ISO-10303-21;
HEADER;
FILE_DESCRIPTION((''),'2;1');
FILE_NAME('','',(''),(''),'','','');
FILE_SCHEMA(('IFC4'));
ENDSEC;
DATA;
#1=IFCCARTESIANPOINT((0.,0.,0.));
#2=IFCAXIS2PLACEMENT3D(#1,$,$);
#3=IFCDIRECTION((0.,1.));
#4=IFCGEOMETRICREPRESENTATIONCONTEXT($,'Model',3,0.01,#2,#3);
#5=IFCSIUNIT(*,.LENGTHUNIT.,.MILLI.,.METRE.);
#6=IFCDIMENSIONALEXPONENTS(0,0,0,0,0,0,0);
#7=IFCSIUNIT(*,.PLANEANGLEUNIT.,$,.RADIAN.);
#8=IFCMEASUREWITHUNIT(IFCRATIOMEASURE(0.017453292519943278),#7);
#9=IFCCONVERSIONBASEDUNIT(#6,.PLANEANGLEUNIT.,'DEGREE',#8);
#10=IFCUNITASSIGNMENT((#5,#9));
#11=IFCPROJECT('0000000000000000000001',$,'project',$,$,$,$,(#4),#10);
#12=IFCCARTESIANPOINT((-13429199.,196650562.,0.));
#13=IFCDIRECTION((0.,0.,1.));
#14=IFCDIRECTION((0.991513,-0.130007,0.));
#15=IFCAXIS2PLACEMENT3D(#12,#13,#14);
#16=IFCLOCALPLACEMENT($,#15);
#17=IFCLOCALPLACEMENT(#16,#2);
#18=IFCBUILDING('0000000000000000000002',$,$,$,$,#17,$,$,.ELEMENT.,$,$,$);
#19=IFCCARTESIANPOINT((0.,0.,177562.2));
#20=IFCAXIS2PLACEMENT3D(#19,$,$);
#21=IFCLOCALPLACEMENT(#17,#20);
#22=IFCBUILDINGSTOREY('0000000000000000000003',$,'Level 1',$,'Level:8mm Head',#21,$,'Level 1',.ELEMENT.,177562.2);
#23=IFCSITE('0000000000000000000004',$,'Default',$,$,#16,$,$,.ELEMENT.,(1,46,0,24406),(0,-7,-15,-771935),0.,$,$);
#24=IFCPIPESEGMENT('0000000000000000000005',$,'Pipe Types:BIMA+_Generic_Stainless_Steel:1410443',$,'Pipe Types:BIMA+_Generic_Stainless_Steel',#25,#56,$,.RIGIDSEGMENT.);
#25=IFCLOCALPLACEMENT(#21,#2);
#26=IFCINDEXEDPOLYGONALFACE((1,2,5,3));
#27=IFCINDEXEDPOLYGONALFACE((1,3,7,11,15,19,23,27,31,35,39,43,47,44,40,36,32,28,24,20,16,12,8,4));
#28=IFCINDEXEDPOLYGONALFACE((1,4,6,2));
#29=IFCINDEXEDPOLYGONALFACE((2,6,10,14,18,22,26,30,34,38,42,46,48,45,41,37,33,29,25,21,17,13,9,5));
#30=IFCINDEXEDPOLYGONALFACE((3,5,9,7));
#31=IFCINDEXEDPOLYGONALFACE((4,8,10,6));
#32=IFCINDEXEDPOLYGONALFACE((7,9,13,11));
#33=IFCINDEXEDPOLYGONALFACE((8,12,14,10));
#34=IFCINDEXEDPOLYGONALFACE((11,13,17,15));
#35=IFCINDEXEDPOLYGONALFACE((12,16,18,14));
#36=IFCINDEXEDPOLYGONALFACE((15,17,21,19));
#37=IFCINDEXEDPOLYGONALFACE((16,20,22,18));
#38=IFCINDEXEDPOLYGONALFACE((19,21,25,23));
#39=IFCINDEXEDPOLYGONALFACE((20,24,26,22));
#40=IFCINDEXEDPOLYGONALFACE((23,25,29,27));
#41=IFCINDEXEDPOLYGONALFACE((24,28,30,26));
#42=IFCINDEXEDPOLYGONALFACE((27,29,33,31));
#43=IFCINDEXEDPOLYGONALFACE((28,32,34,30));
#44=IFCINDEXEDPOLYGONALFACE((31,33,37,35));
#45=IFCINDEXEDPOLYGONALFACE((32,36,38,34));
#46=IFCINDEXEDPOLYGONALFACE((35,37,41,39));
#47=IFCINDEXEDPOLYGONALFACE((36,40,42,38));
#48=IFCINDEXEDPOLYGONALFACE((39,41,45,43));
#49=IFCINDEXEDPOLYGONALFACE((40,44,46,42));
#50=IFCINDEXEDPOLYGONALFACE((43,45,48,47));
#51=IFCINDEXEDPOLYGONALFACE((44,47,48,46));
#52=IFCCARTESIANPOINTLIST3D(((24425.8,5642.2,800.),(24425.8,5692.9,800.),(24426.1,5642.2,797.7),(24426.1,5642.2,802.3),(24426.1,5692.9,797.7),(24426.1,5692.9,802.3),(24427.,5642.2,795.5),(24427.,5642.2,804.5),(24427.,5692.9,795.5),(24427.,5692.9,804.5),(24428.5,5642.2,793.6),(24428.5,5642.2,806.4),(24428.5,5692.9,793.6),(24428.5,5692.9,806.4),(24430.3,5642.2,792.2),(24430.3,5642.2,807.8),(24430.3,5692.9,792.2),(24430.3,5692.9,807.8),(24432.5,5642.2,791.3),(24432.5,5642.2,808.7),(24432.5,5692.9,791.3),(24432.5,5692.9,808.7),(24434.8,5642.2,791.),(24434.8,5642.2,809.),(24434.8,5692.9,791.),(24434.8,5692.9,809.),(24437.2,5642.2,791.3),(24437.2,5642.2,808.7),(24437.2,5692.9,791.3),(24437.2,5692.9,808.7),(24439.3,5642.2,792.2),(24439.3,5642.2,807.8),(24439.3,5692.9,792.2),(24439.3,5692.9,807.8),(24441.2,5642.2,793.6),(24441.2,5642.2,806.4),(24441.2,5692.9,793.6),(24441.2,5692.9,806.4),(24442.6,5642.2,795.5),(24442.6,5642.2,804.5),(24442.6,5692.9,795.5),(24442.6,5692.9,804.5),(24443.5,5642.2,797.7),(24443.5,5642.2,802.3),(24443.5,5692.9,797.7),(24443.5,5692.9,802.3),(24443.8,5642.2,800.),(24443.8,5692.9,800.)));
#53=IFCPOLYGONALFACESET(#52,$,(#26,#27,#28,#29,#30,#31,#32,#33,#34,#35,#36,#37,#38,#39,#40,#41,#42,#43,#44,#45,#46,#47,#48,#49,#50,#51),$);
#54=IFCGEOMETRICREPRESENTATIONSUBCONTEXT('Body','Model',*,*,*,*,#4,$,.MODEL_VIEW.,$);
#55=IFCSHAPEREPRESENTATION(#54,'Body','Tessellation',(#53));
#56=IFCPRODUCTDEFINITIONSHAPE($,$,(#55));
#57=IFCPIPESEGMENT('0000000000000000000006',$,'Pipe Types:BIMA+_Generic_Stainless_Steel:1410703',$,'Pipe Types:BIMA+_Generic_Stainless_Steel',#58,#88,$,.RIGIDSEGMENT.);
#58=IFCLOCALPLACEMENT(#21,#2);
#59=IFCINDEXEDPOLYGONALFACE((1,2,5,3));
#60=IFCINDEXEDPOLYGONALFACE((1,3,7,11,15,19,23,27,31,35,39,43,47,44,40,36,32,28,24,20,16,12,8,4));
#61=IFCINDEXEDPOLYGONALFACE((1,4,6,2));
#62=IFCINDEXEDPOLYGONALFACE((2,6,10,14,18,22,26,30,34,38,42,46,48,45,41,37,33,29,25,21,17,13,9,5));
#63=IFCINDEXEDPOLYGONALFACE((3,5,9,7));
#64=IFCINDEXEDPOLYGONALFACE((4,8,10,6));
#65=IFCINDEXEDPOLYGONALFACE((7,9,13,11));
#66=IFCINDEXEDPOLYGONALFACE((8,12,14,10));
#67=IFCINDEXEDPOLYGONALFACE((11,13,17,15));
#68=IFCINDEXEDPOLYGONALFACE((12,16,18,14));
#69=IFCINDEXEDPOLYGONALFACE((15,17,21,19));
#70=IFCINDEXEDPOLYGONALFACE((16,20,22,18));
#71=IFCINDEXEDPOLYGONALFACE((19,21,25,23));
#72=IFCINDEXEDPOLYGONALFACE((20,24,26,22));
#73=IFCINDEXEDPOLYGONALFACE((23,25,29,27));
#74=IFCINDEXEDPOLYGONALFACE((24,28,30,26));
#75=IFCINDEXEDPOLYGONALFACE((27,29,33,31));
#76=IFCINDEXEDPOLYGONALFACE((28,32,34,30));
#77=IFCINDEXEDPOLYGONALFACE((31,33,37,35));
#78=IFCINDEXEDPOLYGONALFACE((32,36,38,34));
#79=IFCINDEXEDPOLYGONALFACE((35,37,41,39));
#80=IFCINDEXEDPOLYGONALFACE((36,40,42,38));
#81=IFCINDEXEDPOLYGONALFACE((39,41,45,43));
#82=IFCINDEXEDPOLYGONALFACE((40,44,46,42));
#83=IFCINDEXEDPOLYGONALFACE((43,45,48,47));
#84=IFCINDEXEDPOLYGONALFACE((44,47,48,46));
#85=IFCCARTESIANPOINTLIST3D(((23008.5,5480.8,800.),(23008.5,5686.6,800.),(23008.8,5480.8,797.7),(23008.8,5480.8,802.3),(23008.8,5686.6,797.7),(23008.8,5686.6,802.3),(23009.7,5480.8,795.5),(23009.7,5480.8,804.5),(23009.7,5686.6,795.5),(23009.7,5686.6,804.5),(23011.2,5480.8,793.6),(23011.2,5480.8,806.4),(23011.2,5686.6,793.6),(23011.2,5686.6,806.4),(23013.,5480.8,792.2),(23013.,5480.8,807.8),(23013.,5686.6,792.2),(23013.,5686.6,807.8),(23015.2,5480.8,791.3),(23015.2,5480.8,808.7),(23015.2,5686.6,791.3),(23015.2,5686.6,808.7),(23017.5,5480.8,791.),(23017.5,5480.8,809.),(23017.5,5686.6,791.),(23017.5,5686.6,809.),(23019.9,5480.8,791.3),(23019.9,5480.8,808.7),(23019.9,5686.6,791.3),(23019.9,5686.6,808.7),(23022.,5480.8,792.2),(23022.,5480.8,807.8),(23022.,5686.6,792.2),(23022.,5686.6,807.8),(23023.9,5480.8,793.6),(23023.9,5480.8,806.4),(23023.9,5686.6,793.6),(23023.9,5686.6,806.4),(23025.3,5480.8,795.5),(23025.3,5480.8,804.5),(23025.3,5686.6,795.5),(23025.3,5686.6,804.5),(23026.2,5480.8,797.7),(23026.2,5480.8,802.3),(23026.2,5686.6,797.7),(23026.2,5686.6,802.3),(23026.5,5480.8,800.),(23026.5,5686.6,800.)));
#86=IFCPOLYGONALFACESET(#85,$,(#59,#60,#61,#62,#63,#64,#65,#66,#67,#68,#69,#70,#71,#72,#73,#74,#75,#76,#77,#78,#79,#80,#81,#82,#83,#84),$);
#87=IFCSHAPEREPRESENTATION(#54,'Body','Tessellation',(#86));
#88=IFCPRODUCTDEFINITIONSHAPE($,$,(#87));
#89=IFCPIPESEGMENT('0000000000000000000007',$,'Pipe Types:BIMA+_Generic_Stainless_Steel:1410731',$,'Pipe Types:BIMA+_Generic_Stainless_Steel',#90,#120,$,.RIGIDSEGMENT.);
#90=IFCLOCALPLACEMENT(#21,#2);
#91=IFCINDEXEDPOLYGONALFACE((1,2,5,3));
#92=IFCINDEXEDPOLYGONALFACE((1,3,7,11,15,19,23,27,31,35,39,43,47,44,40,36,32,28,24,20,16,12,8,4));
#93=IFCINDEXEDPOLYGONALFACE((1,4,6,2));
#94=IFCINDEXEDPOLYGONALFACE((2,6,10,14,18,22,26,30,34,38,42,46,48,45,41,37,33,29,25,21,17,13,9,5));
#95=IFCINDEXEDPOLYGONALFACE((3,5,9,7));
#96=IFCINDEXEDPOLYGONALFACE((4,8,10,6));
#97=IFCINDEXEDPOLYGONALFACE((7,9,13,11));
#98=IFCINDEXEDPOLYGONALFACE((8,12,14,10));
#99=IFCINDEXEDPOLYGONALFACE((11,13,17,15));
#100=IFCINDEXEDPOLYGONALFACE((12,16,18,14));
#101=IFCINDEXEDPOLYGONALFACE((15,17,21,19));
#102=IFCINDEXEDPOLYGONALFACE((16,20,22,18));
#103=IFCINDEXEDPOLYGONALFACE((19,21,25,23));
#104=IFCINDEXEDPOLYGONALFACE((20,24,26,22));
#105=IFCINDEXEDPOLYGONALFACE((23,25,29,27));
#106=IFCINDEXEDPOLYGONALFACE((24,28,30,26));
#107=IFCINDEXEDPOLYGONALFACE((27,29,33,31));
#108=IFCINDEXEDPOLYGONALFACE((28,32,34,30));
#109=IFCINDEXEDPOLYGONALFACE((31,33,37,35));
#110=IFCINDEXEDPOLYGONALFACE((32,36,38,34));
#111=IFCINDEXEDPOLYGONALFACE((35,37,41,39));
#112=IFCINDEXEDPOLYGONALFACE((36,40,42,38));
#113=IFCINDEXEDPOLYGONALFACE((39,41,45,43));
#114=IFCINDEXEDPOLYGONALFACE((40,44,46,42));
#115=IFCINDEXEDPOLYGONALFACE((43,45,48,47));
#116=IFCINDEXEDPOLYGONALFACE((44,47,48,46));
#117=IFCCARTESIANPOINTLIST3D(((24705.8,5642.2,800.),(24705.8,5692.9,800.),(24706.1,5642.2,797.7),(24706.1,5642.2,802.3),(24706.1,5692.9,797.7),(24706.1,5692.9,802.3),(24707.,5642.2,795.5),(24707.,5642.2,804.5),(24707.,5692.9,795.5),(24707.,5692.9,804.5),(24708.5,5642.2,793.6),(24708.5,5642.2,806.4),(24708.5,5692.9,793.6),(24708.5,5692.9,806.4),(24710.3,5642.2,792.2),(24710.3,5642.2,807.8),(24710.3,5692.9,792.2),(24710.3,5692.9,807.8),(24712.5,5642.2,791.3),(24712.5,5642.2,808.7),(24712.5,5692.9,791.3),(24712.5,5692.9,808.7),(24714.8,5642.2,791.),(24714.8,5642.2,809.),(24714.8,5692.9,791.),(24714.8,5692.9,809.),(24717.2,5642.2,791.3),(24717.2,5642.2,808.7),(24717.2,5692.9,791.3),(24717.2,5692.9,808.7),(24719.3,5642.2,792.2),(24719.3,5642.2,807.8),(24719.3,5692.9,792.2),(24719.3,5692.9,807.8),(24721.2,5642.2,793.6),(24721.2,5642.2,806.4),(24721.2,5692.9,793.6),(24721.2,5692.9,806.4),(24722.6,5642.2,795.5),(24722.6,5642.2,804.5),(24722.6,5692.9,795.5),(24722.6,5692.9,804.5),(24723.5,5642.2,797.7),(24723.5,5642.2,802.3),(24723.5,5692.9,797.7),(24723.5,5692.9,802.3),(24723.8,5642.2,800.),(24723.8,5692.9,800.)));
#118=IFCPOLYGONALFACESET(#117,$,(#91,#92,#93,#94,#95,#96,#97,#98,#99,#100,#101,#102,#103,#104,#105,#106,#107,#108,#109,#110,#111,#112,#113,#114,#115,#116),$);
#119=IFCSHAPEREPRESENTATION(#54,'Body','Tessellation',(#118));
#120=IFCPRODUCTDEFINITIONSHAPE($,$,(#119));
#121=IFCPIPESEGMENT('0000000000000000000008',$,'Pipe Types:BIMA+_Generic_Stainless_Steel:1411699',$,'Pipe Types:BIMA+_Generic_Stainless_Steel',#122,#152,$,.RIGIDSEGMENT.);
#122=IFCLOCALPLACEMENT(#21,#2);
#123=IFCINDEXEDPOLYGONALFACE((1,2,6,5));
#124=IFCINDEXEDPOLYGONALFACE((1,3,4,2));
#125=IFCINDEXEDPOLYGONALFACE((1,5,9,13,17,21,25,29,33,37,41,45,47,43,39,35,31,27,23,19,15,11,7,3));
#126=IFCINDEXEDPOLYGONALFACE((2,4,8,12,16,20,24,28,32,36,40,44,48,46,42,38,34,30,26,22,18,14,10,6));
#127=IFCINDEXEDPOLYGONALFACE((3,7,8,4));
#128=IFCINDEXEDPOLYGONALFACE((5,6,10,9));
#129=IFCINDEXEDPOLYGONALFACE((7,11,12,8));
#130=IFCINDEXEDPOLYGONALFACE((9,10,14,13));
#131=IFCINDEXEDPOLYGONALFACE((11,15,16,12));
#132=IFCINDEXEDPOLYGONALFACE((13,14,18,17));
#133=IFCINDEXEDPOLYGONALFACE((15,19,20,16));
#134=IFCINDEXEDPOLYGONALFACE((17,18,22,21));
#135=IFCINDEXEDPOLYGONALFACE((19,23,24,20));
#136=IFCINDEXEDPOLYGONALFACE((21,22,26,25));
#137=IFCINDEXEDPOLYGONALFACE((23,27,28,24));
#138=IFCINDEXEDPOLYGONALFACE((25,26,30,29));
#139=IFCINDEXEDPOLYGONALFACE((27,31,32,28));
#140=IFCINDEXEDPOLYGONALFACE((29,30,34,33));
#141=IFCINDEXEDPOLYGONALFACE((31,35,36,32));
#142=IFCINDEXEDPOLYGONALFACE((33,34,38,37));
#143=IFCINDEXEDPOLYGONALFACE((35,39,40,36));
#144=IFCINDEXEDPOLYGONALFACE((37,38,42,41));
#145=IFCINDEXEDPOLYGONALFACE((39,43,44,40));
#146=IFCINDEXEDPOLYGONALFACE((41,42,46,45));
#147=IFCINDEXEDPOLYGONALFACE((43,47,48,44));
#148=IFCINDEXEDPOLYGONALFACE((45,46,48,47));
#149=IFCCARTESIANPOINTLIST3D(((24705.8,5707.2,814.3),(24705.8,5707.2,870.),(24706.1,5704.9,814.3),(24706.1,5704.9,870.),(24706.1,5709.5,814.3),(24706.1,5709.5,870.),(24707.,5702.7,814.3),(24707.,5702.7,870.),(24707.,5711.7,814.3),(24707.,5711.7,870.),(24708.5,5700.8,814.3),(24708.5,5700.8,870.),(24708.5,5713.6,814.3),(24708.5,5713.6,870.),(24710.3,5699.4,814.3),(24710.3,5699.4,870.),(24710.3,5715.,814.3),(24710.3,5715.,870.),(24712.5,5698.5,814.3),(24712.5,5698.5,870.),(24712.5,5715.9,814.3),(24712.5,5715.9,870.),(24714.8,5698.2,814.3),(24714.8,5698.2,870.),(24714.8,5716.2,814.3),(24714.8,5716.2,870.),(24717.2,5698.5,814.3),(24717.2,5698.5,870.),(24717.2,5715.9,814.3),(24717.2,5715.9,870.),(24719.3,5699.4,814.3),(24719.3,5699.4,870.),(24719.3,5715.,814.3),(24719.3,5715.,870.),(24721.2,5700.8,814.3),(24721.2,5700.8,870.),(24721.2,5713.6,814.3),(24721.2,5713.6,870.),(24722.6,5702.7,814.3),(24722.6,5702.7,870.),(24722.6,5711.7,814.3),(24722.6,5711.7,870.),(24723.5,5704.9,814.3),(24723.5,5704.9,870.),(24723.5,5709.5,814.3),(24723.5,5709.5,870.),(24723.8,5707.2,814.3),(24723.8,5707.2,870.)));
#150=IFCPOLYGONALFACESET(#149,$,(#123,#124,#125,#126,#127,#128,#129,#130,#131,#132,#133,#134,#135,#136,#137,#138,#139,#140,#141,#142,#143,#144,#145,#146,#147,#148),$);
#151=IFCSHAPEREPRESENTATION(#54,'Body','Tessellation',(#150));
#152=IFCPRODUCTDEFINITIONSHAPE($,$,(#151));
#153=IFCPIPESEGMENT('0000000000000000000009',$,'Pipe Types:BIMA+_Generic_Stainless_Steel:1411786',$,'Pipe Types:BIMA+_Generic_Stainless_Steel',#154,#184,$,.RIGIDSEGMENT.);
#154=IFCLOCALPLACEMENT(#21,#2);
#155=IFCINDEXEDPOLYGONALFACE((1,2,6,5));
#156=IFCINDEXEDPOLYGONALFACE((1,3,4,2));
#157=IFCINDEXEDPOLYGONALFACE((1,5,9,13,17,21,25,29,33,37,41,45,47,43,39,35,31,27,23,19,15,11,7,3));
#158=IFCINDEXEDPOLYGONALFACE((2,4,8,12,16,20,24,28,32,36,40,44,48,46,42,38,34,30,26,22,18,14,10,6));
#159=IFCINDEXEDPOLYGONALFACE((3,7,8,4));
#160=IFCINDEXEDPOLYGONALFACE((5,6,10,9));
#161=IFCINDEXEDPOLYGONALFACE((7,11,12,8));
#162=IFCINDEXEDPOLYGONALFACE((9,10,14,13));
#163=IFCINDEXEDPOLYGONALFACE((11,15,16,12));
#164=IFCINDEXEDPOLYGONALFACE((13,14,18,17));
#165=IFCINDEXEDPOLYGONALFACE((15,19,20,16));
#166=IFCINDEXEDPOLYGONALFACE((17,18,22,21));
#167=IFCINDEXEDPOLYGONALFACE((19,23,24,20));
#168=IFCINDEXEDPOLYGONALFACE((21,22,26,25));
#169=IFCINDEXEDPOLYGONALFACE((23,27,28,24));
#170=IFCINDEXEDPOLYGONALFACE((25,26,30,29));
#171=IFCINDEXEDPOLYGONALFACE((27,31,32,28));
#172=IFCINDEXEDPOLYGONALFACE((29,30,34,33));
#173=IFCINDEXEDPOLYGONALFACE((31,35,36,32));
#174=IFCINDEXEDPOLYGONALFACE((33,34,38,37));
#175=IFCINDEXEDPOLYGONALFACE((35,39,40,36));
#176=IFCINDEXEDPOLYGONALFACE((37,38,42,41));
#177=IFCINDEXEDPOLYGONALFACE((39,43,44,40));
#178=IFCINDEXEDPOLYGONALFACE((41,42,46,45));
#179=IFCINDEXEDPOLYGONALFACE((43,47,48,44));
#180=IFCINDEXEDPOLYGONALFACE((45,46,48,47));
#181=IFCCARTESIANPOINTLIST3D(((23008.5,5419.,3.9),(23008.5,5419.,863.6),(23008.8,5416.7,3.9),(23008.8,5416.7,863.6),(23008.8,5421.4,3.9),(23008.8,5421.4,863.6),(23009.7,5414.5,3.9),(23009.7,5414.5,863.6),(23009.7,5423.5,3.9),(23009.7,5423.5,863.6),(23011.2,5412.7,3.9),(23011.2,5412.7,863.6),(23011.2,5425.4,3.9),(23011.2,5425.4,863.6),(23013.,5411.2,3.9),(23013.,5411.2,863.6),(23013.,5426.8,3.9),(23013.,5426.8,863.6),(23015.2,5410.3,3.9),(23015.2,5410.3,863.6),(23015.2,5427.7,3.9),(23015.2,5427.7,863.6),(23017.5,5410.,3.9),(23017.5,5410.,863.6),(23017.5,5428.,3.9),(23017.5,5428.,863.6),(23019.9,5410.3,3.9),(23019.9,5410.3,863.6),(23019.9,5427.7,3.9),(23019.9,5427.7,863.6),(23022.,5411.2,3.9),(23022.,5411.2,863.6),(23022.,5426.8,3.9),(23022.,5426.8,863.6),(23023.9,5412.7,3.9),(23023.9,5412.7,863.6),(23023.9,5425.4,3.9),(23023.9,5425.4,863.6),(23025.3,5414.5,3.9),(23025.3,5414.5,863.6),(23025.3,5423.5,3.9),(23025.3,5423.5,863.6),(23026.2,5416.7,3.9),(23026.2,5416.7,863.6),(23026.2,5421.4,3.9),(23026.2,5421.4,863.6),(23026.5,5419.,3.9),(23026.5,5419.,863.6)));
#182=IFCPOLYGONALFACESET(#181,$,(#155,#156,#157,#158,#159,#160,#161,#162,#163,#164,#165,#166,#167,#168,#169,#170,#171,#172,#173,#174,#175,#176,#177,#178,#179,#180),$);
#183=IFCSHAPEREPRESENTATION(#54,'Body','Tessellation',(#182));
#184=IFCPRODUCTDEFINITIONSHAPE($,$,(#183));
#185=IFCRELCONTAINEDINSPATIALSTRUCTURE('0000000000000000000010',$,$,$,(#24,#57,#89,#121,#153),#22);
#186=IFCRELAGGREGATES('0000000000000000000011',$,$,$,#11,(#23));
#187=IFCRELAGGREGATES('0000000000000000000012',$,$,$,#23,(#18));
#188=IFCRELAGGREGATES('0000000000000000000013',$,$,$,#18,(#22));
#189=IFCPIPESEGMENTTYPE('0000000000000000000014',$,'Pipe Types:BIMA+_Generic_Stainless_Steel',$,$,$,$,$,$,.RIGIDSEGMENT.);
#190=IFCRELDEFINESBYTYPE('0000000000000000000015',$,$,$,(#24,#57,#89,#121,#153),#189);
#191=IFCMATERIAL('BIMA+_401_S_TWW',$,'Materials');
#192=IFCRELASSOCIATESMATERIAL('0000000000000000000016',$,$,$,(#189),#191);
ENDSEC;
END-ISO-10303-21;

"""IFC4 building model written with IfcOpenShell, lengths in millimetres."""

from ifc_helpers import new_model, entity, si_unit, converted_unit, direction, frame, origin, place, context, subcontext, project, spatial, arc, indexed_curve, outline, extrude, material, type_object, element, save


model = new_model("IFC4")

# Units and contexts
model_context = context("Model", 3, precision=0.01, world=origin(), true_north=direction((0.0, 1.0)))
body_context = subcontext(model_context, "Body", "Model", "MODEL_VIEW")
ifc_project = project(units=[si_unit("LENGTHUNIT", "METRE", prefix="MILLI"), converted_unit("PLANEANGLEUNIT", "DEGREE", entity("IfcRatioMeasure", 0.017453292519943278), si_unit("PLANEANGLEUNIT", "RADIAN"), dimensions=[0, 0, 0, 0, 0, 0, 0])], contexts=[model_context])

# Site, building, storey
site_placement = place(None, frame((-13429199.0, 196650562.0, 0.0), z_axis=(0.0, 0.0, 1.0), x_axis=(0.991513, -0.130007, 0.0)))
site = spatial("IfcSite", under=ifc_project, at=site_placement, Name="Default", CompositionType="ELEMENT", RefLatitude=(1, 46, 0, 24406), RefLongitude=(0, -7, -15, -771935), RefElevation=0.0)
building_placement = place(site_placement, origin())
building = spatial("IfcBuilding", under=site, at=building_placement, CompositionType="ELEMENT")
storey_placement = place(building_placement, frame((0.0, 0.0, 177562.2)))
storey = spatial("IfcBuildingStorey", under=building, at=storey_placement, Name="Level 1", ObjectType="Level:8mm Head", LongName="Level 1", CompositionType="ELEMENT", Elevation=177562.2)

# Pipe segments
ifc_material_1 = material(Name="BIMA+_401_S_TWW", Category="Materials")
pipe_segment_type_1 = type_object("IfcPipeSegmentType", Name="Pipe Types:BIMA+_Generic_Stainless_Steel", PredefinedType="RIGIDSEGMENT", material=ifc_material_1)
pipe_segment_1_placement = place(storey_placement, frame((24424.2, 5642.2, 789.4)))
element("IfcPipeSegment", 1, at=pipe_segment_1_placement, inside=storey, type_object=pipe_segment_type_1, Name="Pipe Types:BIMA+_Generic_Stainless_Steel:1410443", ObjectType="Pipe Types:BIMA+_Generic_Stainless_Steel", PredefinedType="RIGIDSEGMENT", context=body_context, shape_type="SweptSolid", body=[
    extrude(outline(indexed_curve([(9.0, 0.0), (6.4, 6.4), (0.0, 9.0), (-6.4, 6.4), (-9.0, 0.0), (-6.4, -6.4), (0.0, -9.0), (6.4, -6.4)], segments=[arc(1, 2, 3), arc(3, 4, 5), arc(5, 6, 7), arc(7, 8, 1)], self_intersect=False)), frame((10.6, 0.0, 10.6), z_axis=(0.0, 1.0, 0.0), x_axis=(-1.0, 0.0, 0.0)), (0.0, 0.0, 1.0), 50.7),
])
pipe_segment_2_placement = place(storey_placement, frame((23006.9, 5480.8, 789.4)))
element("IfcPipeSegment", 2, at=pipe_segment_2_placement, inside=storey, type_object=pipe_segment_type_1, Name="Pipe Types:BIMA+_Generic_Stainless_Steel:1410703", ObjectType="Pipe Types:BIMA+_Generic_Stainless_Steel", PredefinedType="RIGIDSEGMENT", context=body_context, shape_type="SweptSolid", body=[
    extrude(outline(indexed_curve([(9.0, 0.0), (6.4, 6.4), (0.0, 9.0), (-6.4, 6.4), (-9.0, 0.0), (-6.4, -6.4), (0.0, -9.0), (6.4, -6.4)], segments=[arc(1, 2, 3), arc(3, 4, 5), arc(5, 6, 7), arc(7, 8, 1)], self_intersect=False)), frame((10.6, 0.0, 10.6), z_axis=(0.0, 1.0, 0.0), x_axis=(-1.0, 0.0, 0.0)), (0.0, 0.0, 1.0), 205.8),
])
pipe_segment_3_placement = place(storey_placement, frame((24704.2, 5642.2, 789.4)))
element("IfcPipeSegment", 3, at=pipe_segment_3_placement, inside=storey, type_object=pipe_segment_type_1, Name="Pipe Types:BIMA+_Generic_Stainless_Steel:1410731", ObjectType="Pipe Types:BIMA+_Generic_Stainless_Steel", PredefinedType="RIGIDSEGMENT", context=body_context, shape_type="SweptSolid", body=[
    extrude(outline(indexed_curve([(9.0, 0.0), (6.4, 6.4), (0.0, 9.0), (-6.4, 6.4), (-9.0, 0.0), (-6.4, -6.4), (0.0, -9.0), (6.4, -6.4)], segments=[arc(1, 2, 3), arc(3, 4, 5), arc(5, 6, 7), arc(7, 8, 1)], self_intersect=False)), frame((10.6, 0.0, 10.6), z_axis=(0.0, 1.0, 0.0), x_axis=(-1.0, 0.0, 0.0)), (0.0, 0.0, 1.0), 50.7),
])
pipe_segment_4_placement = place(storey_placement, frame((24704.2, 5696.6, 870.0)))
element("IfcPipeSegment", 4, at=pipe_segment_4_placement, inside=storey, type_object=pipe_segment_type_1, Name="Pipe Types:BIMA+_Generic_Stainless_Steel:1411699", ObjectType="Pipe Types:BIMA+_Generic_Stainless_Steel", PredefinedType="RIGIDSEGMENT", context=body_context, shape_type="SweptSolid", body=[
    extrude(outline(indexed_curve([(9.0, 0.0), (6.4, 6.4), (0.0, 9.0), (-6.4, 6.4), (-9.0, 0.0), (-6.4, -6.4), (0.0, -9.0), (6.4, -6.4)], segments=[arc(1, 2, 3), arc(3, 4, 5), arc(5, 6, 7), arc(7, 8, 1)], self_intersect=False)), frame((10.6, 10.6, -55.7), z_axis=(0.0, 0.0, 1.0), x_axis=(-1.0, 0.0, 0.0)), (0.0, 0.0, 1.0), 55.7),
])
pipe_segment_5_placement = place(storey_placement, frame((23006.9, 5408.4, 863.6)))
element("IfcPipeSegment", 5, at=pipe_segment_5_placement, inside=storey, type_object=pipe_segment_type_1, Name="Pipe Types:BIMA+_Generic_Stainless_Steel:1411786", ObjectType="Pipe Types:BIMA+_Generic_Stainless_Steel", PredefinedType="RIGIDSEGMENT", context=body_context, shape_type="SweptSolid", body=[
    extrude(outline(indexed_curve([(9.0, 0.0), (6.4, 6.4), (0.0, 9.0), (-6.4, 6.4), (-9.0, 0.0), (-6.4, -6.4), (0.0, -9.0), (6.4, -6.4)], segments=[arc(1, 2, 3), arc(3, 4, 5), arc(5, 6, 7), arc(7, 8, 1)], self_intersect=False)), frame((10.6, 10.6, -859.7), z_axis=(0.0, 0.0, 1.0), x_axis=(-1.0, 0.0, 0.0)), (0.0, 0.0, 1.0), 859.7),
])

save(model, "model.ifc")
